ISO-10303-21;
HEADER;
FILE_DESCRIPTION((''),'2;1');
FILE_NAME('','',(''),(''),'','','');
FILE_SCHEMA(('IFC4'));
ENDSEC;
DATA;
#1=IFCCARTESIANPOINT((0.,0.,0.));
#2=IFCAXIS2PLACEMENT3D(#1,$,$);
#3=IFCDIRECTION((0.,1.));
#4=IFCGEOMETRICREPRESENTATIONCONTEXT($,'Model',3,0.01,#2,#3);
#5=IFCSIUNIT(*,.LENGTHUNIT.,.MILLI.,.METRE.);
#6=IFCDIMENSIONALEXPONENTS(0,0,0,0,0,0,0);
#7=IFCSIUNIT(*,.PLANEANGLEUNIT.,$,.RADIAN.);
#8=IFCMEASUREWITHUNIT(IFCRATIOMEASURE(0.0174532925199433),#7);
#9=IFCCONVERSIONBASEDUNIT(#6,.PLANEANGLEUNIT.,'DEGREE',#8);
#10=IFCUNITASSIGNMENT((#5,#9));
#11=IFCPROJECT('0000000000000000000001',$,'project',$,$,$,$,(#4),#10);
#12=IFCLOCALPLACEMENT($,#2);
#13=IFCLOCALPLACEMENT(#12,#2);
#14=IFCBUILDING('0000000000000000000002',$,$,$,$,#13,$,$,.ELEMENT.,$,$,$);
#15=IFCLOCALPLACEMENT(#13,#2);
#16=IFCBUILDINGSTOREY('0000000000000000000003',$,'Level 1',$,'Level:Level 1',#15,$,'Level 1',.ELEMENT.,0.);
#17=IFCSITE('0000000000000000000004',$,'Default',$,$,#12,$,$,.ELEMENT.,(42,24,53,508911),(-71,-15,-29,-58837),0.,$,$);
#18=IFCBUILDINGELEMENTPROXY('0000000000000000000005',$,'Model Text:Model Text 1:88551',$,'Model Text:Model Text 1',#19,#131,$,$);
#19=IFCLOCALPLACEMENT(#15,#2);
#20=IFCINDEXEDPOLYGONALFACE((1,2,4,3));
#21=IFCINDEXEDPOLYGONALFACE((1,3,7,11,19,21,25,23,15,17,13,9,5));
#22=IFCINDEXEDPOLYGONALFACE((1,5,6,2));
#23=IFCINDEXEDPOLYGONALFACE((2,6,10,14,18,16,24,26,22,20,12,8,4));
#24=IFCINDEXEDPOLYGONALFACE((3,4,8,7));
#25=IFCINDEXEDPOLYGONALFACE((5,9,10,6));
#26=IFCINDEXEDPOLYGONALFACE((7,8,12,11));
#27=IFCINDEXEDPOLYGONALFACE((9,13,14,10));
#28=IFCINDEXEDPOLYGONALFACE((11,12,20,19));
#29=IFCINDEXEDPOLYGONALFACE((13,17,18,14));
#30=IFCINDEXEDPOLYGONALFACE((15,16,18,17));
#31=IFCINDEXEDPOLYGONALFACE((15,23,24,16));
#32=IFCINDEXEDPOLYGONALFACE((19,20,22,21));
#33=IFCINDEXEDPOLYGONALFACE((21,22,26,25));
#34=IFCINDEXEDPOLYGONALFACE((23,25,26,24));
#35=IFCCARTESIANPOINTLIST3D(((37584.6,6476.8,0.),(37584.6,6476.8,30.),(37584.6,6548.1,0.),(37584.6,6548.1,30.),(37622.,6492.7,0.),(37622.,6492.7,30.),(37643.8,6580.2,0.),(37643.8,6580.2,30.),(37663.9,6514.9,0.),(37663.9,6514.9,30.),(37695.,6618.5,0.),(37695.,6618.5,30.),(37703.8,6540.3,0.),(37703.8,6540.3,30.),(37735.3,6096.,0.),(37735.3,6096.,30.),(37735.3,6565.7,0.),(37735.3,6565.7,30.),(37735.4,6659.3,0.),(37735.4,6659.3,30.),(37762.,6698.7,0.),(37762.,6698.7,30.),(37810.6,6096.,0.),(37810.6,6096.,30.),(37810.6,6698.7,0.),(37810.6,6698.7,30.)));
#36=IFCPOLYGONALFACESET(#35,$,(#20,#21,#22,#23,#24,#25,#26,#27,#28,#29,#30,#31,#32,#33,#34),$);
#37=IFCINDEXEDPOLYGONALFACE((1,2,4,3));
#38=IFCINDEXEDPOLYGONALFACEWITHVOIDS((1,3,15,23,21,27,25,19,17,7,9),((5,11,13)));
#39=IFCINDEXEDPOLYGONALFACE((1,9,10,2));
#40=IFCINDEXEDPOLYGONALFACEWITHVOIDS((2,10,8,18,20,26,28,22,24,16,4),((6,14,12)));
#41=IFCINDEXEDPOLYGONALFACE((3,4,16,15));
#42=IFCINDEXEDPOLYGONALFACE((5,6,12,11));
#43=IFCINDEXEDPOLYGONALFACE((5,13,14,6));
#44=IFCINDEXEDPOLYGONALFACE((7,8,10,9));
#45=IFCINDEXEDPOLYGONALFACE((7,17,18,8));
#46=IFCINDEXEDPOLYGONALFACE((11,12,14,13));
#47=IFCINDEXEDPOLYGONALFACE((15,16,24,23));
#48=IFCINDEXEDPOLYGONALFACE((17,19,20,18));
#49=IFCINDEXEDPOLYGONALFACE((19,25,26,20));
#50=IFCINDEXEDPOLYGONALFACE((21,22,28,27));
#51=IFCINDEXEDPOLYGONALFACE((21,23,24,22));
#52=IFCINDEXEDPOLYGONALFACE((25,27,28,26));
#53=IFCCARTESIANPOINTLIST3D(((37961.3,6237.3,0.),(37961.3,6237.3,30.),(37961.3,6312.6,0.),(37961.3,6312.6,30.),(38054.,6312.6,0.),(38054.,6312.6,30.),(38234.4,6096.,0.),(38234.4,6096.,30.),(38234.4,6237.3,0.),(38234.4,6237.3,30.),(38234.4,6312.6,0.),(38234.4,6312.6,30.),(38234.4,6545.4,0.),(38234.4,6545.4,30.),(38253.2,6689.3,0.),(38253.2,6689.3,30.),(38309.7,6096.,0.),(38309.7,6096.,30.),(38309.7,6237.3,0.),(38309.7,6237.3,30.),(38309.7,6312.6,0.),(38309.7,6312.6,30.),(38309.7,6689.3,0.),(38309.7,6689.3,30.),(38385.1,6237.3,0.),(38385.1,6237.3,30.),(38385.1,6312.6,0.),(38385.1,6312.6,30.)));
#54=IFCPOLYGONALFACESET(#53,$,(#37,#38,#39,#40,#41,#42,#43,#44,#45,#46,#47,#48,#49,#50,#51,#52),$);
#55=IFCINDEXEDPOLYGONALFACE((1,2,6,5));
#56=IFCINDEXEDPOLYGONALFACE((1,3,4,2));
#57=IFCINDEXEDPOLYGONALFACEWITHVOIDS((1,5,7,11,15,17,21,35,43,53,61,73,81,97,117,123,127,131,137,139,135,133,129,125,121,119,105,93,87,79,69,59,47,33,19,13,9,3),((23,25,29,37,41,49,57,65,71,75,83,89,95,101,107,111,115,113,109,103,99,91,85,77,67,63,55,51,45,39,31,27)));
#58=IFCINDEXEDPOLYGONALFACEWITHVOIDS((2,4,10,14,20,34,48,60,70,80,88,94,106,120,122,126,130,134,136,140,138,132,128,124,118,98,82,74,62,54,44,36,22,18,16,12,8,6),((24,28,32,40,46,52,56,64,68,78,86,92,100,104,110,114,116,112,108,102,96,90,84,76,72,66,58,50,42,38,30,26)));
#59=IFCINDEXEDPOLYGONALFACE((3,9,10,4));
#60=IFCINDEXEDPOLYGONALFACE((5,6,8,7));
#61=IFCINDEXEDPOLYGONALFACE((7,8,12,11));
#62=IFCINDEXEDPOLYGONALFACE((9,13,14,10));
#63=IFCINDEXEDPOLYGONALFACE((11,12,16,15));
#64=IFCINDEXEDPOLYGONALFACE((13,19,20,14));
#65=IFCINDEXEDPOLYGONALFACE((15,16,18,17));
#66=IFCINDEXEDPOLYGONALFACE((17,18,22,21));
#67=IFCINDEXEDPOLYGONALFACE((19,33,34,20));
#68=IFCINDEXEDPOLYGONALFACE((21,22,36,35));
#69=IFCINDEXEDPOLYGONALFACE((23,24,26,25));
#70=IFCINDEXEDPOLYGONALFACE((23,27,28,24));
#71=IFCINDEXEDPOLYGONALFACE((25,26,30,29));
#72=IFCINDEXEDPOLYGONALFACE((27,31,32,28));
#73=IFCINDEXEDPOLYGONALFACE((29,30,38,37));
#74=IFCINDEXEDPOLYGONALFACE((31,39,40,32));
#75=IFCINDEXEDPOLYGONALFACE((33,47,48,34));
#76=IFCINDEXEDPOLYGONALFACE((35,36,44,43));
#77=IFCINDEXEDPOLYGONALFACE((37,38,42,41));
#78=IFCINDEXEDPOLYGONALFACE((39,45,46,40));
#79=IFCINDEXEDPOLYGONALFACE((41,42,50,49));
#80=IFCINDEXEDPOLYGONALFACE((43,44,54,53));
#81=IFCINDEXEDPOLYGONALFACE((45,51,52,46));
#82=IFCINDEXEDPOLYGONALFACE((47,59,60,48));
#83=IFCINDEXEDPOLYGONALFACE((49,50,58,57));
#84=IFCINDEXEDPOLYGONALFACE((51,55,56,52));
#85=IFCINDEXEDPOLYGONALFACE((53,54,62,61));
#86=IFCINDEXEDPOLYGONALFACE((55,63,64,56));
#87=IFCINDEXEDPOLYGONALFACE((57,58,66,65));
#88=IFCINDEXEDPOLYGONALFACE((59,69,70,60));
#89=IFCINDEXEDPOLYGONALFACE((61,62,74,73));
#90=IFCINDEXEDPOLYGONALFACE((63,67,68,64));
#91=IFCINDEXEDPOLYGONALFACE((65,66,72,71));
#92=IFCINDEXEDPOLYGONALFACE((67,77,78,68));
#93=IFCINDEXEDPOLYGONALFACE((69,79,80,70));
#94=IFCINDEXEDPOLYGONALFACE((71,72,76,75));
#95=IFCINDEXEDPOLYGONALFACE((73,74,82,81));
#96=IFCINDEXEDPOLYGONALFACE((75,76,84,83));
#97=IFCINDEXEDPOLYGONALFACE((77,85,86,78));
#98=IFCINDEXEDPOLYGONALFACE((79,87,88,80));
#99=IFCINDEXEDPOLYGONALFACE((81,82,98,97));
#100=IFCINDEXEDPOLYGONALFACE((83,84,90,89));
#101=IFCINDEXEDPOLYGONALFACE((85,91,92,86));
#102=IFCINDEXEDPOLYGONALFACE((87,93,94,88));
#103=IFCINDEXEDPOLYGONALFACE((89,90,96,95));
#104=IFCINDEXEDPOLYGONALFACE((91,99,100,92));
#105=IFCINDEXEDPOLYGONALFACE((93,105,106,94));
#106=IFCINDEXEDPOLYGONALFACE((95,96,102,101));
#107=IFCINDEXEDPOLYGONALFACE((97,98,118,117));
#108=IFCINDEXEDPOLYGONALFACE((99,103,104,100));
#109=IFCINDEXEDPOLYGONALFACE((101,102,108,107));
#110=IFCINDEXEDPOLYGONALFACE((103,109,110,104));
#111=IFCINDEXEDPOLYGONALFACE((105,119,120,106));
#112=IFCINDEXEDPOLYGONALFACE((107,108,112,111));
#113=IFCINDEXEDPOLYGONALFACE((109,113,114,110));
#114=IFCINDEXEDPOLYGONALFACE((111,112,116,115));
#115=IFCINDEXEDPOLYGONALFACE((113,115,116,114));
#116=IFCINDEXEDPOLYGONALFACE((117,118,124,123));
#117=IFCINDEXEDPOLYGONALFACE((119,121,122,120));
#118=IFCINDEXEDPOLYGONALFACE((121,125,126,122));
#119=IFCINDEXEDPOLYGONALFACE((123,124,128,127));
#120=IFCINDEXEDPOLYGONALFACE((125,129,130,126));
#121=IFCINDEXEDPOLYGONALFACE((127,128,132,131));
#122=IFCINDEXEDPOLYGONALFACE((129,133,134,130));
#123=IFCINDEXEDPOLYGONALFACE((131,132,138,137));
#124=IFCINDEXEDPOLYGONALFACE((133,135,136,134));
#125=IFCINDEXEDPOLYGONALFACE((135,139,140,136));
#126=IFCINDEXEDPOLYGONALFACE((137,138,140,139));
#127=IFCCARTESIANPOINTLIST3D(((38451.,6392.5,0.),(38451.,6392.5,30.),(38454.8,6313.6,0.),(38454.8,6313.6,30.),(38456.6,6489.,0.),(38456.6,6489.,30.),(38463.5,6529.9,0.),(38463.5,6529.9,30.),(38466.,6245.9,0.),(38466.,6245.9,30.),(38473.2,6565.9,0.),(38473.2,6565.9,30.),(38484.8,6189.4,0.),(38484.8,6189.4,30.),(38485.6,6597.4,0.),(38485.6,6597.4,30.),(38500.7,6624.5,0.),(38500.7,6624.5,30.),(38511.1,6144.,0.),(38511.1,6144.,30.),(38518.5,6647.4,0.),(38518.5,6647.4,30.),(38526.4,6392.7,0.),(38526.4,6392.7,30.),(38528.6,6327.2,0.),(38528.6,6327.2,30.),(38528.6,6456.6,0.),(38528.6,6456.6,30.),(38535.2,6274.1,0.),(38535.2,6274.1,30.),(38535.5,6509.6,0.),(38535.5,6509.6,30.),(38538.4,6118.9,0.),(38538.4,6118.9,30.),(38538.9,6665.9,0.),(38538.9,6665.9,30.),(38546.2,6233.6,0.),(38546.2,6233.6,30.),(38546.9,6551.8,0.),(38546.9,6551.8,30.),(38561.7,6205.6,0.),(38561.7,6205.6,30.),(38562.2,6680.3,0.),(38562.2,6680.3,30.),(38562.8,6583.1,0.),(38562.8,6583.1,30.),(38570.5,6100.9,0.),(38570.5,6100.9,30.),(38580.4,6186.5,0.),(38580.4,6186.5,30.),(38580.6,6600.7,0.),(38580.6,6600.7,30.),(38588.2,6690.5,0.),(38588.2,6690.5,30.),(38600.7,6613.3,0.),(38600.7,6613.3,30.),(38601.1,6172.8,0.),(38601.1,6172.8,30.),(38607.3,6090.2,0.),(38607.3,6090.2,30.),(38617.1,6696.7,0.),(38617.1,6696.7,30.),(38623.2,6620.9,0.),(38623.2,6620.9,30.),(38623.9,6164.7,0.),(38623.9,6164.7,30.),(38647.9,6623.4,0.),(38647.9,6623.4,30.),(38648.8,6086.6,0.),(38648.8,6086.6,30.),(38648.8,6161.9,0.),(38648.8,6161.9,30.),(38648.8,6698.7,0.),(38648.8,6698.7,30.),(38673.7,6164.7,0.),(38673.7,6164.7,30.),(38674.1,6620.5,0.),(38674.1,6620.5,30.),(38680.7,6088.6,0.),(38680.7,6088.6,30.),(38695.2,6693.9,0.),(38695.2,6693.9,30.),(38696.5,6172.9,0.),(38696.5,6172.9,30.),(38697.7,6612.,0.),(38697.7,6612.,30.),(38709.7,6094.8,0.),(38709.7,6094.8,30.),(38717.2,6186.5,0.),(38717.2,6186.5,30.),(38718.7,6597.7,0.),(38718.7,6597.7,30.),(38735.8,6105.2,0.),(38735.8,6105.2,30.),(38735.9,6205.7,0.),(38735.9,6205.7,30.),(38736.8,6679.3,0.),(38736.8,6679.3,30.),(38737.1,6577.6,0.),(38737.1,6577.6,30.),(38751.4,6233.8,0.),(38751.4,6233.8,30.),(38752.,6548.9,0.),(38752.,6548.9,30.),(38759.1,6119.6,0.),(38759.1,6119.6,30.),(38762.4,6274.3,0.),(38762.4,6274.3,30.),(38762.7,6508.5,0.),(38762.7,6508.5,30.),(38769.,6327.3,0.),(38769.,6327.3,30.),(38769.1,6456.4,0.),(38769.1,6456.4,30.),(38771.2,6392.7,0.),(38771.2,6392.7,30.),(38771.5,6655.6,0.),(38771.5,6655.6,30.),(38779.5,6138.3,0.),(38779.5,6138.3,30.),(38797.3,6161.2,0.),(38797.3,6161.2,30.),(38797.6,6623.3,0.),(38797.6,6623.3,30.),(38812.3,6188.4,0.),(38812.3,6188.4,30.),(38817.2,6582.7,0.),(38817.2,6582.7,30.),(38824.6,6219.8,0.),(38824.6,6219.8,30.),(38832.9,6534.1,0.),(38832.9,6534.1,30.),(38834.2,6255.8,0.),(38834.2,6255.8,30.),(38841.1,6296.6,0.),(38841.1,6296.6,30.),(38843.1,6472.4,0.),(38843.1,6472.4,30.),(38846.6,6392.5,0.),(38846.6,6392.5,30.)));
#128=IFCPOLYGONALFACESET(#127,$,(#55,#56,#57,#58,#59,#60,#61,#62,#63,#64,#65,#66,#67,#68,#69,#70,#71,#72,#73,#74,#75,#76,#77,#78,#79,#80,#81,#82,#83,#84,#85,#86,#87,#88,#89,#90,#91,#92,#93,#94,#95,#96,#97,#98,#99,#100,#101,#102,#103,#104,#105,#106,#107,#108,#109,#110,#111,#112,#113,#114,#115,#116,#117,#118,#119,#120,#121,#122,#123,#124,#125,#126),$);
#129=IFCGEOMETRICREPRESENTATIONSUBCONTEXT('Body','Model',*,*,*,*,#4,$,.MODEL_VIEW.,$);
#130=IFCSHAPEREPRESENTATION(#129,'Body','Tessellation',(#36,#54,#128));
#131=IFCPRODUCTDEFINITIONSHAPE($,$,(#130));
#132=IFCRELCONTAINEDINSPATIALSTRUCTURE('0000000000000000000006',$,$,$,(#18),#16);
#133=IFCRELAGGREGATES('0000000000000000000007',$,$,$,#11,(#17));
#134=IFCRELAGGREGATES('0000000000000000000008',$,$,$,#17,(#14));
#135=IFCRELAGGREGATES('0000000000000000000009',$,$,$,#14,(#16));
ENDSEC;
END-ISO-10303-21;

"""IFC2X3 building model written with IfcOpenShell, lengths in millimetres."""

from ifc_helpers import new_model, entity, si_unit, converted_unit, direction, frame, origin, place, context, subcontext, project, spatial, polyline, outline, extrude, element, save


model = new_model("IFC2X3")

# Units and contexts
model_context = context("Model", 3, precision=0.01, world=origin(), true_north=direction((0.0, 1.0)))
body_context = subcontext(model_context, "Body", "Model", "MODEL_VIEW")
ifc_project = project(units=[si_unit("LENGTHUNIT", "METRE", prefix="MILLI"), converted_unit("PLANEANGLEUNIT", "DEGREE", entity("IfcRatioMeasure", 0.0174532925199433), si_unit("PLANEANGLEUNIT", "RADIAN"), dimensions=[0, 0, 0, 0, 0, 0, 0])], contexts=[model_context])

# Site, building, storey
site_placement = place(None, origin())
site = spatial("IfcSite", under=ifc_project, at=site_placement, Name="Default", CompositionType="ELEMENT", RefLatitude=(42, 24, 53, 508911), RefLongitude=(-71, -15, -29, -58837), RefElevation=0.0)
building_placement = place(site_placement, origin())
building = spatial("IfcBuilding", under=site, at=building_placement, CompositionType="ELEMENT")
storey_placement = place(building_placement, origin())
storey = spatial("IfcBuildingStorey", under=building, at=storey_placement, Name="Level 1", ObjectType="Level:Level 1", LongName="Level 1", CompositionType="ELEMENT", Elevation=0.0)

# Building element proxy
proxy_1_placement = place(storey_placement, origin())
element("IfcBuildingElementProxy", 1, at=proxy_1_placement, inside=storey, Name="Model Text:Model Text 1:88551", ObjectType="Model Text:Model Text 1", context=body_context, shape_type="SweptSolid", body=[
    extrude(outline(polyline([(-410.6, -111.6), (192.1, -111.6), (192.1, -63.1), (152.7, -36.4), (111.9, 4.0), (73.6, 55.2), (41.4, 114.4), (-29.8, 114.4), (-13.9, 77.0), (8.3, 35.1), (33.7, -4.8), (59.1, -36.3), (-410.6, -36.3), (-410.6, -111.6)])), frame((37699.0, 6506.6, 0.0), z_axis=(0.0, 0.0, 1.0), x_axis=(0.0, 1.0, 0.0)), (0.0, 0.0, 1.0), 30.0),
    extrude(outline(polyline([(-6.8, -218.3), (68.5, -218.3), (68.5, -77.1), (143.8, -77.1), (143.8, -1.7), (68.5, -1.7), (68.5, 375.0), (12.0, 375.0), (-280.0, -1.7), (-280.0, -77.1), (-6.8, -77.1), (-6.8, -218.3)]), holes=[polyline([(-6.8, -1.7), (-187.3, -1.7), (-6.8, 231.1), (-6.8, -1.7)])]), frame((38241.3, 6314.3, 0.0)), (0.0, 0.0, 1.0), 30.0),
    extrude(outline(polyline([(-10.6, -198.7), (68.3, -198.7), (136.5, -190.7), (193.9, -174.7), (240.5, -150.6), (266.9, -124.4), (286.3, -93.2), (298.8, -57.0), (304.3, -15.7), (303.8, 16.2), (299.0, 45.5), (289.9, 72.1), (276.6, 96.0), (258.9, 117.3), (236.9, 136.2), (210.4, 152.5), (179.6, 166.3), (144.1, 177.6), (103.7, 186.3), (8.2, 196.4), (-71.8, 196.7), (-134.0, 189.4), (-183.3, 176.1), (-224.7, 158.4), (-258.2, 133.9), (-283.5, 100.3), (-300.1, 59.5), (-307.1, 13.4), (-306.6, -18.4), (-301.8, -47.5), (-292.8, -74.0), (-279.6, -97.9), (-262.0, -119.2), (-240.0, -138.1), (-213.6, -154.5), (-182.8, -168.4), (-147.3, -179.8), (-106.7, -188.6), (-10.6, -198.7)]), holes=[polyline([(-7.2, -123.5), (-71.0, -118.2), (-123.6, -108.8), (-165.2, -95.4), (-195.7, -78.0), (-212.4, -59.4), (-224.1, -38.7), (-230.6, -15.9), (-231.9, 8.9), (-227.8, 35.0), (-218.1, 58.1), (-202.8, 78.4), (-182.0, 95.8), (-152.6, 109.4), (-111.7, 118.1), (-59.4, 122.0), (4.4, 121.1), (69.6, 115.8), (122.2, 106.7), (162.2, 93.7), (189.5, 77.0), (207.7, 57.4), (220.4, 36.0), (227.5, 12.8), (229.1, -12.1), (225.2, -36.8), (215.9, -59.2), (201.3, -79.3), (181.4, -97.1), (152.6, -111.2), (111.6, -120.3), (58.3, -124.4), (-7.2, -123.5)])]), frame((38650.0, 6391.3, 0.0), z_axis=(0.0, 0.0, 1.0), x_axis=(0.047515, -0.998871, 0.0)), (0.0, 0.0, 1.0), 30.0),
])

save(model, "model.ifc")
